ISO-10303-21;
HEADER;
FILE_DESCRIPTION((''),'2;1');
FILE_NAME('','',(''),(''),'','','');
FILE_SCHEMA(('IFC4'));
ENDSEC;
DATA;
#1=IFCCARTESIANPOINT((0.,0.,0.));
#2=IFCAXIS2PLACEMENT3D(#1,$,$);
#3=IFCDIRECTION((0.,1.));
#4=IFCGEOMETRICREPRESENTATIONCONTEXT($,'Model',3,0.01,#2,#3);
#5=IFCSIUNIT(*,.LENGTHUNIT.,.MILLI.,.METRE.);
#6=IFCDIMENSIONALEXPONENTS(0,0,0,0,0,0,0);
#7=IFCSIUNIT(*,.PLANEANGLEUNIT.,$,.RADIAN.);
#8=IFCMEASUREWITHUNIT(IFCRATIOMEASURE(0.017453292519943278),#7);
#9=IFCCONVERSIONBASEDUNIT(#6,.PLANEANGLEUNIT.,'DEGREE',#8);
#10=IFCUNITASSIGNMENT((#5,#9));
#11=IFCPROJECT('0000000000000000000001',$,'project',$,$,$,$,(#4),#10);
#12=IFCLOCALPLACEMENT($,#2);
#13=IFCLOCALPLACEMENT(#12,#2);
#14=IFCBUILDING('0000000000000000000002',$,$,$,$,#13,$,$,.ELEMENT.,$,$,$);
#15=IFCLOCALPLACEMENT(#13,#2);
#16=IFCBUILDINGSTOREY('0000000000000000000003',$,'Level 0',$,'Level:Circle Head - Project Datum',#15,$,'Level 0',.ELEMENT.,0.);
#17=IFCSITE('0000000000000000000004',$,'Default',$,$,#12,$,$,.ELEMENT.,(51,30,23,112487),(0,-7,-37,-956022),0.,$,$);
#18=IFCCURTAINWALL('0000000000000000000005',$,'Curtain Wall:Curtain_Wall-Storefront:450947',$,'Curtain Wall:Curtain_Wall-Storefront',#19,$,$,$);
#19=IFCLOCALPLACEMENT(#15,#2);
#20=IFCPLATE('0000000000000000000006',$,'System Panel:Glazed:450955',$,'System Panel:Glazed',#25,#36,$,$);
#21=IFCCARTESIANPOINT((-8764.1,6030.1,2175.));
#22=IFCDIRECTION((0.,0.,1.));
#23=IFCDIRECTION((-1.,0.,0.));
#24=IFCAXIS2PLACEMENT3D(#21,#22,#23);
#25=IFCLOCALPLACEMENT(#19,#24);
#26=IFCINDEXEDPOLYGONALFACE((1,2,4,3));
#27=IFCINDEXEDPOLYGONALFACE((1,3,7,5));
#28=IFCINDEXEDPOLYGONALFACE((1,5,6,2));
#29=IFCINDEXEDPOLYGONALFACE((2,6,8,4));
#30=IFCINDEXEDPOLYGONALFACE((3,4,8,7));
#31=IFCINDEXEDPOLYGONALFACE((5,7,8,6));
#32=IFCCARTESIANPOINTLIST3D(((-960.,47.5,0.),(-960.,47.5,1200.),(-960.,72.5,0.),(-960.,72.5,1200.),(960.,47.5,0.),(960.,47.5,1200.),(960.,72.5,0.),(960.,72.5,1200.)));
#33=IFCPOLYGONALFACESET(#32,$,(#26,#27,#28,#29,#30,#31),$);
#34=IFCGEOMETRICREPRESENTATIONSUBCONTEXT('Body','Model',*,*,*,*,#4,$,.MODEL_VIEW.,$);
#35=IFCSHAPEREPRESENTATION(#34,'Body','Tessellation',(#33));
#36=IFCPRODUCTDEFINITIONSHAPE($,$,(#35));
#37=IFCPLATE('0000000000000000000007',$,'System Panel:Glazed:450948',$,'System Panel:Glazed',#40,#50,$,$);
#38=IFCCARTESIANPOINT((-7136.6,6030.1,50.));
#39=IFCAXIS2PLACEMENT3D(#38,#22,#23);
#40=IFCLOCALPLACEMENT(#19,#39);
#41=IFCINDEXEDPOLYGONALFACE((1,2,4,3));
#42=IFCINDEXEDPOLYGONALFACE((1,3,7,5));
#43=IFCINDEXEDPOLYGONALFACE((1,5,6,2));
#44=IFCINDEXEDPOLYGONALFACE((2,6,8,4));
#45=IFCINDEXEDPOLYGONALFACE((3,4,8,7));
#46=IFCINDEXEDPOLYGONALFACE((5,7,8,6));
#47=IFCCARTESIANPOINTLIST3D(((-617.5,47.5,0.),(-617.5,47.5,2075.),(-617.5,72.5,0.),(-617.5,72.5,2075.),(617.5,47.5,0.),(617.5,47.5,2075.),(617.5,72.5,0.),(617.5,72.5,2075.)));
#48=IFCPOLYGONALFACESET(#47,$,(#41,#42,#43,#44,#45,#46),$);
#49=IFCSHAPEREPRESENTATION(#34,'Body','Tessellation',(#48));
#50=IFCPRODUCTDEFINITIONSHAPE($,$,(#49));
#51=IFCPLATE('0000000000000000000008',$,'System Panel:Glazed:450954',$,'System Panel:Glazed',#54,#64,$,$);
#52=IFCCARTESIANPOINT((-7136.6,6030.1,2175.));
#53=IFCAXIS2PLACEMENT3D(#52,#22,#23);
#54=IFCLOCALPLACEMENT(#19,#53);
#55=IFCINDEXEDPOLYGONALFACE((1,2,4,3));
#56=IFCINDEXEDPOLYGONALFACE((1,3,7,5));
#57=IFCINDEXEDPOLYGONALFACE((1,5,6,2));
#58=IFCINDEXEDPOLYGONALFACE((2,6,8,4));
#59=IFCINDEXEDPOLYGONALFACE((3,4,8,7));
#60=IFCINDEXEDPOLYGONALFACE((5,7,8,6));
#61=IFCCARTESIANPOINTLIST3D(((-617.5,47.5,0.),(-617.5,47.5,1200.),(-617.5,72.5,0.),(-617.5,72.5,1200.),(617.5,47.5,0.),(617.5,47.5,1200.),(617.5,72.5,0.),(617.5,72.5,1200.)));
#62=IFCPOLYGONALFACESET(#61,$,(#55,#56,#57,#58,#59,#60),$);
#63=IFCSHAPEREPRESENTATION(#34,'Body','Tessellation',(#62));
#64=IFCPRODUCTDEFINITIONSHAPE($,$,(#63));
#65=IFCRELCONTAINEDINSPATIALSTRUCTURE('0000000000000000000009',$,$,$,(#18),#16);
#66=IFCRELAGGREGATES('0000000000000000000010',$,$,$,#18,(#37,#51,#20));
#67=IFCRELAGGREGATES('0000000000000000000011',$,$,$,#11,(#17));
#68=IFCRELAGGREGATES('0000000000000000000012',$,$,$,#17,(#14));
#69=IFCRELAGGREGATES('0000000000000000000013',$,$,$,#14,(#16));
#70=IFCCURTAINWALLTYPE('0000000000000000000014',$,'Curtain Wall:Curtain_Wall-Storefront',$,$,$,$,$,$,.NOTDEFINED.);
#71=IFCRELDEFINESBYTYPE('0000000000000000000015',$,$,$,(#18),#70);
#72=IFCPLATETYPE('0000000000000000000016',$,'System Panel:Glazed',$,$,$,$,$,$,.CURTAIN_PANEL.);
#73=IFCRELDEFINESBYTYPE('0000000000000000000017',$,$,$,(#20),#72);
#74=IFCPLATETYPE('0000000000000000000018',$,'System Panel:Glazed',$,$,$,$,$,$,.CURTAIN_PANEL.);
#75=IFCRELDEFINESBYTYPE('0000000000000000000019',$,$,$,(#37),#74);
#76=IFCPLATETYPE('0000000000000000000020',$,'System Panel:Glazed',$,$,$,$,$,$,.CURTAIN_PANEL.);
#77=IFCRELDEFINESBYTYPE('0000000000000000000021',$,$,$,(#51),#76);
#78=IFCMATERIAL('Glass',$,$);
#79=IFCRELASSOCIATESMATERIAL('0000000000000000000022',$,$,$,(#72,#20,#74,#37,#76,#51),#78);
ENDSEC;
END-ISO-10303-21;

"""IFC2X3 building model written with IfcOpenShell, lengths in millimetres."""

from ifc_helpers import new_model, entity, si_unit, converted_unit, direction, frame, origin, origin_2d_with_axis, place, context, subcontext, project, spatial, rectangle, extrude, source, transform, mapped, material, type_object, type_shapes, element, aggregate, save


model = new_model("IFC2X3")

# Units and contexts
model_context = context("Model", 3, precision=0.01, world=origin(), true_north=direction((0.0, 1.0)))
body_context = subcontext(model_context, "Body", "Model", "MODEL_VIEW")
ifc_project = project(units=[si_unit("LENGTHUNIT", "METRE", prefix="MILLI"), converted_unit("PLANEANGLEUNIT", "DEGREE", entity("IfcRatioMeasure", 0.017453292519943278), si_unit("PLANEANGLEUNIT", "RADIAN"), dimensions=[0, 0, 0, 0, 0, 0, 0])], contexts=[model_context])

# Site, building, storey
site_placement = place(None, origin())
site = spatial("IfcSite", under=ifc_project, at=site_placement, Name="Default", CompositionType="ELEMENT", RefLatitude=(51, 30, 23, 112487), RefLongitude=(0, -7, -37, -956022), RefElevation=0.0)
building_placement = place(site_placement, origin())
building = spatial("IfcBuilding", under=site, at=building_placement, CompositionType="ELEMENT")
storey_placement = place(building_placement, origin())
storey = spatial("IfcBuildingStorey", under=building, at=storey_placement, Name="Level 0", ObjectType="Level:Circle Head - Project Datum", LongName="Level 0", CompositionType="ELEMENT", Elevation=0.0)

# Curtain wall
curtain_wall_type_1 = type_object("IfcCurtainWallType", Name="Curtain Wall:Curtain_Wall-Storefront", PredefinedType="NOTDEFINED")
curtain_wall_1_placement = place(storey_placement, origin())
curtain_wall_1 = element("IfcCurtainWall", 1, at=curtain_wall_1_placement, inside=storey, type_object=curtain_wall_type_1, Name="Curtain Wall:Curtain_Wall-Storefront:450947", ObjectType="Curtain Wall:Curtain_Wall-Storefront")

# Plates
ifc_material_1 = material(Name="Glass")
plate_type_1 = type_object("IfcPlateType", Name="System Panel:Glazed", PredefinedType="CURTAIN_PANEL", material=ifc_material_1)
shared_shape_1 = source(origin(), body_context, "Body", "SweptSolid", [
    extrude(rectangle(XDim=25.0, YDim=1920.0, at=origin_2d_with_axis()), frame((0.0, 60.0, 0.0), z_axis=(0.0, 0.0, 1.0), x_axis=(0.0, 1.0, 0.0)), (0.0, 0.0, 1.0), 1200.0),
])
type_shapes(plate_type_1, [shared_shape_1])
plate_1_placement = place(curtain_wall_1_placement, frame((-8764.1, 6030.1, 2175.0), z_axis=(0.0, 0.0, 1.0), x_axis=(-1.0, 0.0, 0.0)))
plate_1 = element("IfcPlate", 2, at=plate_1_placement, type_object=plate_type_1, material=ifc_material_1, Name="System Panel:Glazed:450955", ObjectType="System Panel:Glazed", context=body_context, shape_type="MappedRepresentation", body=[
    mapped(shared_shape_1, transform((0.0, 0.0, 0.0), scale=1.0)),
])
plate_type_2 = type_object("IfcPlateType", Name="System Panel:Glazed", PredefinedType="CURTAIN_PANEL", material=ifc_material_1)
shared_shape_2 = source(origin(), body_context, "Body", "SweptSolid", [
    extrude(rectangle(XDim=25.0, YDim=1235.0, at=origin_2d_with_axis()), frame((0.0, 60.0, 0.0), z_axis=(0.0, 0.0, 1.0), x_axis=(0.0, 1.0, 0.0)), (0.0, 0.0, 1.0), 2075.0),
])
type_shapes(plate_type_2, [shared_shape_2])
plate_2_placement = place(curtain_wall_1_placement, frame((-7136.6, 6030.1, 50.0), z_axis=(0.0, 0.0, 1.0), x_axis=(-1.0, 0.0, 0.0)))
plate_2 = element("IfcPlate", 3, at=plate_2_placement, type_object=plate_type_2, material=ifc_material_1, Name="System Panel:Glazed:450948", ObjectType="System Panel:Glazed", context=body_context, shape_type="MappedRepresentation", body=[
    mapped(shared_shape_2, transform((0.0, 0.0, 0.0), scale=1.0)),
])
plate_type_3 = type_object("IfcPlateType", Name="System Panel:Glazed", PredefinedType="CURTAIN_PANEL", material=ifc_material_1)
shared_shape_3 = source(origin(), body_context, "Body", "SweptSolid", [
    extrude(rectangle(XDim=25.0, YDim=1235.0, at=origin_2d_with_axis()), frame((0.0, 60.0, 0.0), z_axis=(0.0, 0.0, 1.0), x_axis=(0.0, 1.0, 0.0)), (0.0, 0.0, 1.0), 1200.0),
])
type_shapes(plate_type_3, [shared_shape_3])
plate_3_placement = place(curtain_wall_1_placement, frame((-7136.6, 6030.1, 2175.0), z_axis=(0.0, 0.0, 1.0), x_axis=(-1.0, 0.0, 0.0)))
plate_3 = element("IfcPlate", 4, at=plate_3_placement, type_object=plate_type_3, material=ifc_material_1, Name="System Panel:Glazed:450954", ObjectType="System Panel:Glazed", context=body_context, shape_type="MappedRepresentation", body=[
    mapped(shared_shape_3, transform((0.0, 0.0, 0.0), scale=1.0)),
])
aggregate(curtain_wall_1, [plate_2, plate_3, plate_1])

save(model, "model.ifc")
